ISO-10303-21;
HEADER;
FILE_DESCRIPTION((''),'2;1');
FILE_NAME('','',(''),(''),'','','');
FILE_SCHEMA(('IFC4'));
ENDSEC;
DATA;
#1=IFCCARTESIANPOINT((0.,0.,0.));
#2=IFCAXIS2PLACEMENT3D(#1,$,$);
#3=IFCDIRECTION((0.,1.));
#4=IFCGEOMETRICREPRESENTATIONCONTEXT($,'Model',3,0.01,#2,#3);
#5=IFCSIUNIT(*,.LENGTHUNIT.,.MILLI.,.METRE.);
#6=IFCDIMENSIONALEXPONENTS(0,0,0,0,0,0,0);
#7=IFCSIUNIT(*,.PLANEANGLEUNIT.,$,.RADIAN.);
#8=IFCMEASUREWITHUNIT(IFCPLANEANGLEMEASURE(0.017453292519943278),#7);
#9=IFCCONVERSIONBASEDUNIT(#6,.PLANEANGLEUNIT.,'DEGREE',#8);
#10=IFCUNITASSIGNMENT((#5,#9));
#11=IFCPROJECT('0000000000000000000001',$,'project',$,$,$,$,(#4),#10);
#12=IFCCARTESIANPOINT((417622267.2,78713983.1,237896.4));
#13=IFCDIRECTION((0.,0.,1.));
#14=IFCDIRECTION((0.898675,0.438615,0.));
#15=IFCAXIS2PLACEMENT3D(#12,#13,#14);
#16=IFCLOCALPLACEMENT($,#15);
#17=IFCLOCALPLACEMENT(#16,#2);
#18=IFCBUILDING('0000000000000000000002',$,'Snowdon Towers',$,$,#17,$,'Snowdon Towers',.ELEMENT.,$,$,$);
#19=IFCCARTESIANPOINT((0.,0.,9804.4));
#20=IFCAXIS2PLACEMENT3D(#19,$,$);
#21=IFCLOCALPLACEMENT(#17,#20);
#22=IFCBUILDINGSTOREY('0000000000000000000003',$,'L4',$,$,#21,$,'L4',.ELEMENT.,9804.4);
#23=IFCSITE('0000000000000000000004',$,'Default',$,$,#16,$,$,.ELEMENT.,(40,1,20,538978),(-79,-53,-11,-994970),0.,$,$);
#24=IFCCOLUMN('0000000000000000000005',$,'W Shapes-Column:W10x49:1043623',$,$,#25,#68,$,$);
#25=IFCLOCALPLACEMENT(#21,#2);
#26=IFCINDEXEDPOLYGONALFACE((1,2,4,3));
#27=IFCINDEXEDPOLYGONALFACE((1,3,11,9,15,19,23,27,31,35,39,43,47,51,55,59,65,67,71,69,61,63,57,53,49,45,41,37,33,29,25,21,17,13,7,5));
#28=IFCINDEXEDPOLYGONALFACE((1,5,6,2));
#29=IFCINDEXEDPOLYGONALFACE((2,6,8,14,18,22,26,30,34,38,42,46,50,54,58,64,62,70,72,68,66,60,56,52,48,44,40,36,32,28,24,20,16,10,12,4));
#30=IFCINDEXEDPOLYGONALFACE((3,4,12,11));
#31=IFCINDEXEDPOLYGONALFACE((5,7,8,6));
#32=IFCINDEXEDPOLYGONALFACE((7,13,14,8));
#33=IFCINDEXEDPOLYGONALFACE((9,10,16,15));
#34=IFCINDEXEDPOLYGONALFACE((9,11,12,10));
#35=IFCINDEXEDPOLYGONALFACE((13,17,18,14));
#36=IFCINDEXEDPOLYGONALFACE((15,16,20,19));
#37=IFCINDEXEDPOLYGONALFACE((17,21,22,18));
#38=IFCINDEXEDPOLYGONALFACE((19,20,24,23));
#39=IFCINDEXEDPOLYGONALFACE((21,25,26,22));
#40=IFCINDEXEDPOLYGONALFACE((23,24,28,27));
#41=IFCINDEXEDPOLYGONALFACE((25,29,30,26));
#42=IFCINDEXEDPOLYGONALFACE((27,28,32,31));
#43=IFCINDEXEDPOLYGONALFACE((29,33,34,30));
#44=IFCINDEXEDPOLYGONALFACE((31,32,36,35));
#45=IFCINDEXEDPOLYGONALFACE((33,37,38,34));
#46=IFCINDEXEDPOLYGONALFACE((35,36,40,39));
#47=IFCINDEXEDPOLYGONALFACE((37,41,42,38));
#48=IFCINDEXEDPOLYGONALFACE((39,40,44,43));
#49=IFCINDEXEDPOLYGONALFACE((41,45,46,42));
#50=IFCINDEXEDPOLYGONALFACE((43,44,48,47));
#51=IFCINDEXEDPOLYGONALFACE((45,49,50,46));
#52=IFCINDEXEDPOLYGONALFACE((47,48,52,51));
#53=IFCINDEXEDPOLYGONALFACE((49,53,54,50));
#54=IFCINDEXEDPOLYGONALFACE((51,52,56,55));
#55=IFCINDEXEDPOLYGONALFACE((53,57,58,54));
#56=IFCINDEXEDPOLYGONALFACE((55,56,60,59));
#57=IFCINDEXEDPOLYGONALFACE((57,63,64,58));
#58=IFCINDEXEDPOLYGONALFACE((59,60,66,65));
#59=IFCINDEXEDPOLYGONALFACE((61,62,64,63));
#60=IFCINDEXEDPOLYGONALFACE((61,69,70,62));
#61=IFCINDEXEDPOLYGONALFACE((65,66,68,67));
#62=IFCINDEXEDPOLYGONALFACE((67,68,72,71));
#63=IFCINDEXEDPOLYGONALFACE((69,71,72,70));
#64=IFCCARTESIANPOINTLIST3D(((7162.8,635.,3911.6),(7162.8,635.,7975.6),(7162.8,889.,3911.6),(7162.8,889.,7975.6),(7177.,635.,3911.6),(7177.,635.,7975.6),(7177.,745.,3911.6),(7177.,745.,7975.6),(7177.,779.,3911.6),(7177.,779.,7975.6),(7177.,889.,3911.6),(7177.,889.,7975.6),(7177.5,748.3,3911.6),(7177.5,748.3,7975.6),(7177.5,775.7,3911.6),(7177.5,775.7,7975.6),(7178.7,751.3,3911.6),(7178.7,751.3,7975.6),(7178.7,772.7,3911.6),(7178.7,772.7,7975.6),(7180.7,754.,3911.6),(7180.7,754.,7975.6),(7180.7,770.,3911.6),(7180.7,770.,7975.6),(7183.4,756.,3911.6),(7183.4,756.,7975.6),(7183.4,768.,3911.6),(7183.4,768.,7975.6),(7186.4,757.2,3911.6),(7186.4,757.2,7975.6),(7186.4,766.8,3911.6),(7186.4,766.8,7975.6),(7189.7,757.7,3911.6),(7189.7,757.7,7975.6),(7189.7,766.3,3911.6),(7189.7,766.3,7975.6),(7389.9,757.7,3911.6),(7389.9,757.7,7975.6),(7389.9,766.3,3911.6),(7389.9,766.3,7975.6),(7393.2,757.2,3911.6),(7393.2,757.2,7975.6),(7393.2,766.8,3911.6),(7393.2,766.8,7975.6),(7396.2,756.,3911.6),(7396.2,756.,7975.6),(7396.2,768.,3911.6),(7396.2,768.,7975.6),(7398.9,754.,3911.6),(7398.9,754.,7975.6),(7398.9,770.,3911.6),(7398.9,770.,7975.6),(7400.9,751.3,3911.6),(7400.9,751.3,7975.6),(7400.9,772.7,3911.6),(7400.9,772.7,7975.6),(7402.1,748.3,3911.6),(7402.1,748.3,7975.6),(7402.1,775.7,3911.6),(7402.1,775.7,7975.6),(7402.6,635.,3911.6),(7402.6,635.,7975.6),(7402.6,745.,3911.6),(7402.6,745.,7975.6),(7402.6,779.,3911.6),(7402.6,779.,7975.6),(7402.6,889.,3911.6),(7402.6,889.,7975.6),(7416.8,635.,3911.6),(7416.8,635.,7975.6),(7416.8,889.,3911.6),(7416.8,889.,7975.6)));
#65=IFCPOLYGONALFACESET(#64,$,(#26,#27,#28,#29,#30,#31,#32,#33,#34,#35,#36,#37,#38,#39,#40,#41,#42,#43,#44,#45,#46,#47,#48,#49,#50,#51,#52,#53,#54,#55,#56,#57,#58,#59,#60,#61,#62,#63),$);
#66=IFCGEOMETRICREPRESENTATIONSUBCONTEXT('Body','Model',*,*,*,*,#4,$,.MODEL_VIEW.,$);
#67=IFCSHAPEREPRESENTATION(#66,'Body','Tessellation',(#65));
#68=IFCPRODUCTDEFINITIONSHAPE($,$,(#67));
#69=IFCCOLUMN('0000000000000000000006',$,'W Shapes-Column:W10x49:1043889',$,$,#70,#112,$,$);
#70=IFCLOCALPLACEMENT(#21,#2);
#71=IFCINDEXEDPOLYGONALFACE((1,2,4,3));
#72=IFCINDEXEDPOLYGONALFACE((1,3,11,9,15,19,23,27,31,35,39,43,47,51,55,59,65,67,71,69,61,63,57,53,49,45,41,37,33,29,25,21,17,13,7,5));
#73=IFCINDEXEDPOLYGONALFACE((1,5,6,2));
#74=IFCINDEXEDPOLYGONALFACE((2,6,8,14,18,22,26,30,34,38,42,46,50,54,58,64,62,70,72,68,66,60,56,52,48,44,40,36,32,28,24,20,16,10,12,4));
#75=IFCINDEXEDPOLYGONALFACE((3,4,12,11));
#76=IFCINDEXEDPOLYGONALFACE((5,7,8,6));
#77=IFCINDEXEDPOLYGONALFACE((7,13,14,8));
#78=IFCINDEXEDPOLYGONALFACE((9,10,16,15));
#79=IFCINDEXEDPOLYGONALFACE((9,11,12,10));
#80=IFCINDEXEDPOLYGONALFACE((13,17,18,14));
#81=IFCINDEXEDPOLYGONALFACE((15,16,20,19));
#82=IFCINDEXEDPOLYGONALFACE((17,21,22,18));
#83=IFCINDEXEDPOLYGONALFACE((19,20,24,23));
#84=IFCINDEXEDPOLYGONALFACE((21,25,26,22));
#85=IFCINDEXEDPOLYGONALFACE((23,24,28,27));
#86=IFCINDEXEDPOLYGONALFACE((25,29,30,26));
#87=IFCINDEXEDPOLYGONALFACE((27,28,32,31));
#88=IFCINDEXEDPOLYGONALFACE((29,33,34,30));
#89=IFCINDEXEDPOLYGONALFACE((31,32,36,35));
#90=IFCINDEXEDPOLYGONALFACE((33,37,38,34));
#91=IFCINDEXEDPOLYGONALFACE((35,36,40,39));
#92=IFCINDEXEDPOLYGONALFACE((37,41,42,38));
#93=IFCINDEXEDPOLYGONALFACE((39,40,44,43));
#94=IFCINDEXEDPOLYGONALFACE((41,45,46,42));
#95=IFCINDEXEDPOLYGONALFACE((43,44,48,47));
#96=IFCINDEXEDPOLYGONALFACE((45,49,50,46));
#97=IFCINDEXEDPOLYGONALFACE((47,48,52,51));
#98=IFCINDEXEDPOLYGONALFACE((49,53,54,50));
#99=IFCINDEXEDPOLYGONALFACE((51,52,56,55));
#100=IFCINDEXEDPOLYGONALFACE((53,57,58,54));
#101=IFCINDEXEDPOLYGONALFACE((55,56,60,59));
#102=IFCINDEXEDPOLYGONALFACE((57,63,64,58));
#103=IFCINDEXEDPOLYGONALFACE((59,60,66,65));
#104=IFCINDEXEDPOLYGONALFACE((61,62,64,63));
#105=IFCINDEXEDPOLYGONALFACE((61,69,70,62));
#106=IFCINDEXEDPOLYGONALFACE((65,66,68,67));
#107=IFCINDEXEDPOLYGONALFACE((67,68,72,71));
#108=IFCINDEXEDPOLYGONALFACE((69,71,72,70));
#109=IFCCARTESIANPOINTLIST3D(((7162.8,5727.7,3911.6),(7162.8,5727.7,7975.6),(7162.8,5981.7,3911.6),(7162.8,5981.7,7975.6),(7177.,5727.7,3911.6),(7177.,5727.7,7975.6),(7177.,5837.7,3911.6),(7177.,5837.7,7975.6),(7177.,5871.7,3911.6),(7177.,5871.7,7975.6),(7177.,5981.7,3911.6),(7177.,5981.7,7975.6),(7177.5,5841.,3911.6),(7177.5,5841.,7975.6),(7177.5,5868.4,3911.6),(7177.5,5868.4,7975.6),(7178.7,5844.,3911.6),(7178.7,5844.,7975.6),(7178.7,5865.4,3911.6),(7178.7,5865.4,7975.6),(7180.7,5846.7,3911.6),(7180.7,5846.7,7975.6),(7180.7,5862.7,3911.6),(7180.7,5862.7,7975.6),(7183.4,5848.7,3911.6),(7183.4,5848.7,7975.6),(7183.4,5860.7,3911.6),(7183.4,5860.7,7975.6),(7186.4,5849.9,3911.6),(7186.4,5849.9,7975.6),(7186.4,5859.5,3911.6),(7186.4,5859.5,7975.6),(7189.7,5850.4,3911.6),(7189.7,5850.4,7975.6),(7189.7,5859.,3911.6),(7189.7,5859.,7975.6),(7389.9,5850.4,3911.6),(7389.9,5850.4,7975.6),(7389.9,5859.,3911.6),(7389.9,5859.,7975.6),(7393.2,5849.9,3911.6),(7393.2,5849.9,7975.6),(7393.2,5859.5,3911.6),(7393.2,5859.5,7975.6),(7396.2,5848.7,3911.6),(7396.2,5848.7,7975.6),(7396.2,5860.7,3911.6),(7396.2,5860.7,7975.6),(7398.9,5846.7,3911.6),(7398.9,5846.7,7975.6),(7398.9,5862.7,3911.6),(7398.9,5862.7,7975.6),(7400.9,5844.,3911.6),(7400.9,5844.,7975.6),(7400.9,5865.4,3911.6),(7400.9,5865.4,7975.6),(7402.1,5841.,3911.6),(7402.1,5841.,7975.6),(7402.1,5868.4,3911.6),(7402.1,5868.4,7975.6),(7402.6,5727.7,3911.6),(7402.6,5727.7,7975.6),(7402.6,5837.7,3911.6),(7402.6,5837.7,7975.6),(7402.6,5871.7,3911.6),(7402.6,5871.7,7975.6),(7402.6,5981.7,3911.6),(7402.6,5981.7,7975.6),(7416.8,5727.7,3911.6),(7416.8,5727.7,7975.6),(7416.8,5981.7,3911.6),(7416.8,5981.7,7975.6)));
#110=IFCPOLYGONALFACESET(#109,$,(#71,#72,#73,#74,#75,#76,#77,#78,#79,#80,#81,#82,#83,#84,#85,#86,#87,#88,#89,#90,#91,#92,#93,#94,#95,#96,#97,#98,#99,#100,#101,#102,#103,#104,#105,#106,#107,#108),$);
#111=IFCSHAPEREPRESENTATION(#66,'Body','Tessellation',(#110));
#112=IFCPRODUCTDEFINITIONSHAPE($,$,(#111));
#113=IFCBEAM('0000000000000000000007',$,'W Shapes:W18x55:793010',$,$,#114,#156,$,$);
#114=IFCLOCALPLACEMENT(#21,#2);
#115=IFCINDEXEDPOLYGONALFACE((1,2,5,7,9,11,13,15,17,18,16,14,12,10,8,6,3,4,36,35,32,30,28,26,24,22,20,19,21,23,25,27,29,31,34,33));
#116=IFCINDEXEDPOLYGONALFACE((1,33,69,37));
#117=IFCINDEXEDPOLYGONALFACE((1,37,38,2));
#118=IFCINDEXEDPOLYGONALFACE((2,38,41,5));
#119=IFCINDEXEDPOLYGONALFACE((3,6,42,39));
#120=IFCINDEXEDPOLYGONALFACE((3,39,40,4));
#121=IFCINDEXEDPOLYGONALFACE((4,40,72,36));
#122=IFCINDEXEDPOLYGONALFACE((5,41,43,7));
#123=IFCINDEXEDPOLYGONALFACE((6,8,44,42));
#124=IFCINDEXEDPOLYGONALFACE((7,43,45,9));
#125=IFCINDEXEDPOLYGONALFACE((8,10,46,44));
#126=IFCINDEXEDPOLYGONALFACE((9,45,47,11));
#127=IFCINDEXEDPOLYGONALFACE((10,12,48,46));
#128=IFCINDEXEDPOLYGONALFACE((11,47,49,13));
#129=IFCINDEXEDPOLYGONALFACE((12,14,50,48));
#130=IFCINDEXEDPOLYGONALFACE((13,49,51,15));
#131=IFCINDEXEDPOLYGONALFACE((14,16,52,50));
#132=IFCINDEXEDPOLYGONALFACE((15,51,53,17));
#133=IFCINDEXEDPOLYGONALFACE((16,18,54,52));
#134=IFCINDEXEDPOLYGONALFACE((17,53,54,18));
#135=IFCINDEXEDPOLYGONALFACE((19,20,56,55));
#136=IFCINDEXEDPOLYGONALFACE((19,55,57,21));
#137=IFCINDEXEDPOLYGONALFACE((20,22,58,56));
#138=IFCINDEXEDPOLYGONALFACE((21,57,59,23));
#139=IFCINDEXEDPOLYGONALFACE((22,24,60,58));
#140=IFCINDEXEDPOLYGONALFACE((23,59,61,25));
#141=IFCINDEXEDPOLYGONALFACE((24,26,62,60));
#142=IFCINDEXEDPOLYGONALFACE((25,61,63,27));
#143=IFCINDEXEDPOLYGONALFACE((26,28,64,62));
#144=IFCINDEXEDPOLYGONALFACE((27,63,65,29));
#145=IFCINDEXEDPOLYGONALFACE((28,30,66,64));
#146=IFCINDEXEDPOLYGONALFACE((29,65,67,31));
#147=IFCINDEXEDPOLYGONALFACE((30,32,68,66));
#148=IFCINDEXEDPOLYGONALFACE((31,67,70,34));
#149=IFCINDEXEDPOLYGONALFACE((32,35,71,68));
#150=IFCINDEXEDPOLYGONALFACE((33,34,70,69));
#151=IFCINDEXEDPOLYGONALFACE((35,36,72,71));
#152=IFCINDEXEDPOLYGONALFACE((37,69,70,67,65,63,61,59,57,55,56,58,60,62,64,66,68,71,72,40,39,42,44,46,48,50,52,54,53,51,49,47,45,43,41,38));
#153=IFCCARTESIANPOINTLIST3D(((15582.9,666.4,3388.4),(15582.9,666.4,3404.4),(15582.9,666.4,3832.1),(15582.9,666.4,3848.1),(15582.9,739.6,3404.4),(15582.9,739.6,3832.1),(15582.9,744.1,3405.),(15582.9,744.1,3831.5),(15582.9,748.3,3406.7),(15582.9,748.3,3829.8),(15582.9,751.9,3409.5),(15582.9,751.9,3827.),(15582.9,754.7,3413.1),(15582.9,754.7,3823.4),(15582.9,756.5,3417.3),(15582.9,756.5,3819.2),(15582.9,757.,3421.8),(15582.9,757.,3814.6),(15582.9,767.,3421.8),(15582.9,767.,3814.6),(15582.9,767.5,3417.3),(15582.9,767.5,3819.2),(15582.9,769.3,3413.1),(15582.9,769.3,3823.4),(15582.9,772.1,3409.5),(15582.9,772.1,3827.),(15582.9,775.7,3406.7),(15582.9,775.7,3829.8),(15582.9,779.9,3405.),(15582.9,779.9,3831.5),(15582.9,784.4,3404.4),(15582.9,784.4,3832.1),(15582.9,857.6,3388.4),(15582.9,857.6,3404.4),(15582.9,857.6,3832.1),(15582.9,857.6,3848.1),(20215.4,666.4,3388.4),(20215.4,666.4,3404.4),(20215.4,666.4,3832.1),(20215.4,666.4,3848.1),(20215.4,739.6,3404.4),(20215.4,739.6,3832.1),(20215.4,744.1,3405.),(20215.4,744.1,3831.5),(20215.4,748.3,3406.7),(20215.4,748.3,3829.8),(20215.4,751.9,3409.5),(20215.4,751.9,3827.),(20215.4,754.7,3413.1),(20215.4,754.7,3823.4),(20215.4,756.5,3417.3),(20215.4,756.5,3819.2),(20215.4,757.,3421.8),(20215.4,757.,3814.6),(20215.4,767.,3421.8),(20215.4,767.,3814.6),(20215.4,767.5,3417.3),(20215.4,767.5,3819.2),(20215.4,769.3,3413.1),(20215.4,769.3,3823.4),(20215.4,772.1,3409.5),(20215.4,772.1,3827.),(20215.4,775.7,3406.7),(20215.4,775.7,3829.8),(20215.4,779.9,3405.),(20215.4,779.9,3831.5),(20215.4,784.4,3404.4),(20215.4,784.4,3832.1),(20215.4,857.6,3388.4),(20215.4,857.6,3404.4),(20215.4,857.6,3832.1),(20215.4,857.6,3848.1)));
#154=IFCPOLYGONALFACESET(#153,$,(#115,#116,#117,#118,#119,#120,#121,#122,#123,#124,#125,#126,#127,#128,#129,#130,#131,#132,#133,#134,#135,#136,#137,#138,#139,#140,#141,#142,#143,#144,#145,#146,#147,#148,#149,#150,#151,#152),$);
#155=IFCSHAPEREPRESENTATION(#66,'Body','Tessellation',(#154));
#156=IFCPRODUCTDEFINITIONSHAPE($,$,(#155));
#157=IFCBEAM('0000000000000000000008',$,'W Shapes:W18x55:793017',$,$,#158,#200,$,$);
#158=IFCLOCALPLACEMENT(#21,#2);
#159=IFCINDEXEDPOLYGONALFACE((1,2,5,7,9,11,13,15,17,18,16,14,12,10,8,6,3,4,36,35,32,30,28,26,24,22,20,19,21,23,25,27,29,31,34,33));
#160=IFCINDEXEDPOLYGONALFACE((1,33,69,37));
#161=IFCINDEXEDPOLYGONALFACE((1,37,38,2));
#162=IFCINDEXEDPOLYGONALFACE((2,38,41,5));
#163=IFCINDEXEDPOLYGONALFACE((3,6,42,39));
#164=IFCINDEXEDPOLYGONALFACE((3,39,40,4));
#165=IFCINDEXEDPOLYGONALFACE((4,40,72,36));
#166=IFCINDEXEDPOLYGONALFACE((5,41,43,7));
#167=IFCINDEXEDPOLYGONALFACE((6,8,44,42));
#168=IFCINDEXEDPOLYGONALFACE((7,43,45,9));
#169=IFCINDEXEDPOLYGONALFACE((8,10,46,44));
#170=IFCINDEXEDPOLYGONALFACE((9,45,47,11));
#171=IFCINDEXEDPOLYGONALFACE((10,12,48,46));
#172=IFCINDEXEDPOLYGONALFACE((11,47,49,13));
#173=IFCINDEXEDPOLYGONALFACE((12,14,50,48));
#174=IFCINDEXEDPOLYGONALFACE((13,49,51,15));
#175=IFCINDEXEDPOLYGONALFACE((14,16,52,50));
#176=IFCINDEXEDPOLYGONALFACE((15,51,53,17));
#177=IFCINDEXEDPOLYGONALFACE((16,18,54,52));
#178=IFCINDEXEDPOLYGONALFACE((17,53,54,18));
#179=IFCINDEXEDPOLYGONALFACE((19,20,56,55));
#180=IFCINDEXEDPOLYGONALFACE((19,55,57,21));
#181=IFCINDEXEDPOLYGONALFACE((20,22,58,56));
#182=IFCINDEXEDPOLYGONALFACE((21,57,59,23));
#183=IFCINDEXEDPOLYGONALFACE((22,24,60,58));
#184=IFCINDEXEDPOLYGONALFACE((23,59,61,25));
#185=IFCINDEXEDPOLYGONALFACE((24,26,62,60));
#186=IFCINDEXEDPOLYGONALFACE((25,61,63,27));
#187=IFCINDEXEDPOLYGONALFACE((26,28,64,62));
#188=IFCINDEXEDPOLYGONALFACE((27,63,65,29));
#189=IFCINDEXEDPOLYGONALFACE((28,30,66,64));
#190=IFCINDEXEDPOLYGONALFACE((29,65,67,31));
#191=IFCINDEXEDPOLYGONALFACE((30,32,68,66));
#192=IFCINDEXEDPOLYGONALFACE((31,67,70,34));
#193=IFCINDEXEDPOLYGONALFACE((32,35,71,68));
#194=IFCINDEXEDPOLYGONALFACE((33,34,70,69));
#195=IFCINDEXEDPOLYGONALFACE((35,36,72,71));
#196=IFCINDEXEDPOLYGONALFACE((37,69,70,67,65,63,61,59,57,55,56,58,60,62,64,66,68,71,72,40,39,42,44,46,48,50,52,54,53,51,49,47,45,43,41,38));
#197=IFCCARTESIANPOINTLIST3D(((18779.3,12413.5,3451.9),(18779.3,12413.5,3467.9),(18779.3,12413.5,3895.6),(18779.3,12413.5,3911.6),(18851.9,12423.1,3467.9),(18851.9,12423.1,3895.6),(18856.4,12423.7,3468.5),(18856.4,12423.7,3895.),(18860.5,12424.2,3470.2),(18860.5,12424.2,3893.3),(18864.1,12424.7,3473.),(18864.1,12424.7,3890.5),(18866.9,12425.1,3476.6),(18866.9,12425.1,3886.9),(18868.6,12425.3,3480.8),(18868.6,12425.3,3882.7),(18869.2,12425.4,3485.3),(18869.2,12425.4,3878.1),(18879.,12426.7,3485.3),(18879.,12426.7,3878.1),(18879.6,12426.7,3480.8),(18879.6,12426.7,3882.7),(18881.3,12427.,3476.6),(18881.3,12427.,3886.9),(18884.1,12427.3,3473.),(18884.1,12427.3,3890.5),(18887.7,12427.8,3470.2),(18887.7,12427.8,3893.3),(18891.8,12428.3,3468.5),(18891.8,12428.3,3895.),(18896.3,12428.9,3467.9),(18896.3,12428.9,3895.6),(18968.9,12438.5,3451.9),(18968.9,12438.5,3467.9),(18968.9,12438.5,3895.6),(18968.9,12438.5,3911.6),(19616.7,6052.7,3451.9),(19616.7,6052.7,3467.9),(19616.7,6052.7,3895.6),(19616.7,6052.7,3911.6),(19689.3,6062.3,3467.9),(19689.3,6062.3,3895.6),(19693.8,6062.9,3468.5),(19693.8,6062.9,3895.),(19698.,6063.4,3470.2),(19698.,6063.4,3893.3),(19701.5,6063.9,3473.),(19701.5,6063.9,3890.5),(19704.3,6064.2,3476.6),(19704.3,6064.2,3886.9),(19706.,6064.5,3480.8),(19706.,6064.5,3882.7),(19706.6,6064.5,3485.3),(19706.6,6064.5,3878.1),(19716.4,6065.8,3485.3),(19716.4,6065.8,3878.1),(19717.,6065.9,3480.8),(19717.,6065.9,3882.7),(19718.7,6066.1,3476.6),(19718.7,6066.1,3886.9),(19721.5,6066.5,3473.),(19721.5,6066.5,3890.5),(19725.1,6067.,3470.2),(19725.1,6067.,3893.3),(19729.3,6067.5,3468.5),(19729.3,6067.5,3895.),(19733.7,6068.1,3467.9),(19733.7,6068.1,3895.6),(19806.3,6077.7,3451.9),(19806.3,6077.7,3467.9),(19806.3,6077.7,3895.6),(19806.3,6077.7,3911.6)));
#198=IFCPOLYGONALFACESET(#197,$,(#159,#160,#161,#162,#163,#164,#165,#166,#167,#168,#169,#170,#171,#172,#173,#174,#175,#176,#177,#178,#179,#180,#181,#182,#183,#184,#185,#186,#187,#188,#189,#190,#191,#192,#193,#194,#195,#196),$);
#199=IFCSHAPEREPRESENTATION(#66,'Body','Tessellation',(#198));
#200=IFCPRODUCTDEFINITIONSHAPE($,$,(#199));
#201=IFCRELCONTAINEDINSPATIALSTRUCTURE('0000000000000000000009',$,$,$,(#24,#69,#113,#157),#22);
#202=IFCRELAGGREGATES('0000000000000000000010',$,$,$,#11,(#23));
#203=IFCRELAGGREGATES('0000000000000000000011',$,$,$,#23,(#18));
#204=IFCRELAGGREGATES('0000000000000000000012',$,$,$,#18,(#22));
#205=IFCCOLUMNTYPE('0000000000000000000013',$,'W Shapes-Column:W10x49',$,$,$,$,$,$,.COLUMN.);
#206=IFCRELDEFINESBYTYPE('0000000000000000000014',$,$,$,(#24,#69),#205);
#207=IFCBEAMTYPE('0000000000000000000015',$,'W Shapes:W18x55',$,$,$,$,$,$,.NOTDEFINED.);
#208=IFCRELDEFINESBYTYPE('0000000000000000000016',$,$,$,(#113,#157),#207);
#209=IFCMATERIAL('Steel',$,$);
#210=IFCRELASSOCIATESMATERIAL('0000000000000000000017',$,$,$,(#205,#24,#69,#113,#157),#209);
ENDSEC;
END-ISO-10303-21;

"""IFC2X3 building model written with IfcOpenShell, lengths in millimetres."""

from ifc_helpers import new_model, entity, si_unit, converted_unit, direction, frame, frame_2d, origin, place, context, subcontext, project, spatial, i_section, extrude, source, transform, mapped, material, type_object, type_shapes, element, save


model = new_model("IFC2X3")

# Units and contexts
model_context = context("Model", 3, precision=0.01, world=origin(), true_north=direction((0.0, 1.0)))
body_context = subcontext(model_context, "Body", "Model", "MODEL_VIEW")
ifc_project = project(units=[si_unit("LENGTHUNIT", "METRE", prefix="MILLI"), converted_unit("PLANEANGLEUNIT", "DEGREE", entity("IfcPlaneAngleMeasure", 0.017453292519943278), si_unit("PLANEANGLEUNIT", "RADIAN"), dimensions=[0, 0, 0, 0, 0, 0, 0])], contexts=[model_context])

# Site, building, storey
site_placement = place(None, frame((417622267.2, 78713983.1, 237896.4), z_axis=(0.0, 0.0, 1.0), x_axis=(0.898675, 0.438615, 0.0)))
site = spatial("IfcSite", under=ifc_project, at=site_placement, Name="Default", CompositionType="ELEMENT", RefLatitude=(40, 1, 20, 538978), RefLongitude=(-79, -53, -11, -994970), RefElevation=0.0)
building_placement = place(site_placement, origin())
building = spatial("IfcBuilding", under=site, at=building_placement, Name="Snowdon Towers", LongName="Snowdon Towers", CompositionType="ELEMENT")
storey_placement = place(building_placement, frame((0.0, 0.0, 9804.4)))
storey = spatial("IfcBuildingStorey", under=building, at=storey_placement, Name="L4", LongName="L4", CompositionType="ELEMENT", Elevation=9804.4)

# Columns
ifc_material_1 = material(Name="Steel")
column_type_1 = type_object("IfcColumnType", Name="W Shapes-Column:W10x49", PredefinedType="COLUMN", material=ifc_material_1)
shared_shape_1 = source(origin(), body_context, "Body", "SweptSolid", [
    extrude(i_section(OverallWidth=254.0, OverallDepth=254.0, WebThickness=8.6, FlangeThickness=14.2, FilletRadius=12.7, at=frame_2d((0.0, 0.0), x_axis=(1.0, 0.0))), frame((0.0, 0.0, 13716.0), z_axis=(0.0, 0.0, 1.0), x_axis=(-1.0, 0.0, 0.0)), (0.0, 0.0, 1.0), 4064.0),
])
type_shapes(column_type_1, [shared_shape_1])
for number, where, z_axis, x_axis, name in (
    (1, (7289.8, 762.0, -9804.4), (0.0, 0.0, 1.0), (0.0, 1.0, 0.0), "W Shapes-Column:W10x49:1043623"),
    (2, (7289.8, 5854.7, -9804.4), (0.0, 0.0, 1.0), (0.0, 1.0, 0.0), "W Shapes-Column:W10x49:1043889"),
):
    element("IfcColumn", number, at=place(storey_placement, frame(where, z_axis=z_axis, x_axis=x_axis)), inside=storey, type_object=column_type_1, material=ifc_material_1, Name=name, context=body_context, shape_type="MappedRepresentation", body=[
        mapped(shared_shape_1, transform((0.0, 0.0, 0.0), scale=1.0)),
    ])

# Beams
beam_type = type_object("IfcBeamType", Name="W Shapes:W18x55", PredefinedType="NOTDEFINED")
beam_1_placement = place(storey_placement, frame((15582.9, 762.0, 3911.6)))
element("IfcBeam", 3, at=beam_1_placement, inside=storey, type_object=beam_type, material=ifc_material_1, Name="W Shapes:W18x55:793010", context=body_context, shape_type="SweptSolid", body=[
    extrude(i_section(OverallWidth=191.3, OverallDepth=459.7, WebThickness=9.9, FlangeThickness=16.0, FilletRadius=17.5, at=frame_2d((0.0, 0.0), x_axis=(0.0, 1.0))), frame((0.0, 0.0, -293.4), z_axis=(1.0, 0.0, 0.0), x_axis=(0.0, 0.0, -1.0)), (0.0, 0.0, 1.0), 4632.5),
])
beam_2_placement = place(storey_placement, frame((18846.4, 12636.5, 3911.6), z_axis=(0.0, 0.0, 1.0), x_axis=(0.130526, -0.991445, 0.0)))
element("IfcBeam", 4, at=beam_2_placement, inside=storey, type_object=beam_type, material=ifc_material_1, Name="W Shapes:W18x55:793017", context=body_context, shape_type="SweptSolid", body=[
    extrude(i_section(OverallWidth=191.3, OverallDepth=459.7, WebThickness=9.9, FlangeThickness=16.0, FilletRadius=17.5, at=frame_2d((0.0, 0.0), x_axis=(0.0, 1.0))), frame((212.3, 0.0, -229.9), z_axis=(1.0, 0.0, 0.0), x_axis=(0.0, 0.0, -1.0)), (0.0, 0.0, 1.0), 6415.7),
])

save(model, "model.ifc")
